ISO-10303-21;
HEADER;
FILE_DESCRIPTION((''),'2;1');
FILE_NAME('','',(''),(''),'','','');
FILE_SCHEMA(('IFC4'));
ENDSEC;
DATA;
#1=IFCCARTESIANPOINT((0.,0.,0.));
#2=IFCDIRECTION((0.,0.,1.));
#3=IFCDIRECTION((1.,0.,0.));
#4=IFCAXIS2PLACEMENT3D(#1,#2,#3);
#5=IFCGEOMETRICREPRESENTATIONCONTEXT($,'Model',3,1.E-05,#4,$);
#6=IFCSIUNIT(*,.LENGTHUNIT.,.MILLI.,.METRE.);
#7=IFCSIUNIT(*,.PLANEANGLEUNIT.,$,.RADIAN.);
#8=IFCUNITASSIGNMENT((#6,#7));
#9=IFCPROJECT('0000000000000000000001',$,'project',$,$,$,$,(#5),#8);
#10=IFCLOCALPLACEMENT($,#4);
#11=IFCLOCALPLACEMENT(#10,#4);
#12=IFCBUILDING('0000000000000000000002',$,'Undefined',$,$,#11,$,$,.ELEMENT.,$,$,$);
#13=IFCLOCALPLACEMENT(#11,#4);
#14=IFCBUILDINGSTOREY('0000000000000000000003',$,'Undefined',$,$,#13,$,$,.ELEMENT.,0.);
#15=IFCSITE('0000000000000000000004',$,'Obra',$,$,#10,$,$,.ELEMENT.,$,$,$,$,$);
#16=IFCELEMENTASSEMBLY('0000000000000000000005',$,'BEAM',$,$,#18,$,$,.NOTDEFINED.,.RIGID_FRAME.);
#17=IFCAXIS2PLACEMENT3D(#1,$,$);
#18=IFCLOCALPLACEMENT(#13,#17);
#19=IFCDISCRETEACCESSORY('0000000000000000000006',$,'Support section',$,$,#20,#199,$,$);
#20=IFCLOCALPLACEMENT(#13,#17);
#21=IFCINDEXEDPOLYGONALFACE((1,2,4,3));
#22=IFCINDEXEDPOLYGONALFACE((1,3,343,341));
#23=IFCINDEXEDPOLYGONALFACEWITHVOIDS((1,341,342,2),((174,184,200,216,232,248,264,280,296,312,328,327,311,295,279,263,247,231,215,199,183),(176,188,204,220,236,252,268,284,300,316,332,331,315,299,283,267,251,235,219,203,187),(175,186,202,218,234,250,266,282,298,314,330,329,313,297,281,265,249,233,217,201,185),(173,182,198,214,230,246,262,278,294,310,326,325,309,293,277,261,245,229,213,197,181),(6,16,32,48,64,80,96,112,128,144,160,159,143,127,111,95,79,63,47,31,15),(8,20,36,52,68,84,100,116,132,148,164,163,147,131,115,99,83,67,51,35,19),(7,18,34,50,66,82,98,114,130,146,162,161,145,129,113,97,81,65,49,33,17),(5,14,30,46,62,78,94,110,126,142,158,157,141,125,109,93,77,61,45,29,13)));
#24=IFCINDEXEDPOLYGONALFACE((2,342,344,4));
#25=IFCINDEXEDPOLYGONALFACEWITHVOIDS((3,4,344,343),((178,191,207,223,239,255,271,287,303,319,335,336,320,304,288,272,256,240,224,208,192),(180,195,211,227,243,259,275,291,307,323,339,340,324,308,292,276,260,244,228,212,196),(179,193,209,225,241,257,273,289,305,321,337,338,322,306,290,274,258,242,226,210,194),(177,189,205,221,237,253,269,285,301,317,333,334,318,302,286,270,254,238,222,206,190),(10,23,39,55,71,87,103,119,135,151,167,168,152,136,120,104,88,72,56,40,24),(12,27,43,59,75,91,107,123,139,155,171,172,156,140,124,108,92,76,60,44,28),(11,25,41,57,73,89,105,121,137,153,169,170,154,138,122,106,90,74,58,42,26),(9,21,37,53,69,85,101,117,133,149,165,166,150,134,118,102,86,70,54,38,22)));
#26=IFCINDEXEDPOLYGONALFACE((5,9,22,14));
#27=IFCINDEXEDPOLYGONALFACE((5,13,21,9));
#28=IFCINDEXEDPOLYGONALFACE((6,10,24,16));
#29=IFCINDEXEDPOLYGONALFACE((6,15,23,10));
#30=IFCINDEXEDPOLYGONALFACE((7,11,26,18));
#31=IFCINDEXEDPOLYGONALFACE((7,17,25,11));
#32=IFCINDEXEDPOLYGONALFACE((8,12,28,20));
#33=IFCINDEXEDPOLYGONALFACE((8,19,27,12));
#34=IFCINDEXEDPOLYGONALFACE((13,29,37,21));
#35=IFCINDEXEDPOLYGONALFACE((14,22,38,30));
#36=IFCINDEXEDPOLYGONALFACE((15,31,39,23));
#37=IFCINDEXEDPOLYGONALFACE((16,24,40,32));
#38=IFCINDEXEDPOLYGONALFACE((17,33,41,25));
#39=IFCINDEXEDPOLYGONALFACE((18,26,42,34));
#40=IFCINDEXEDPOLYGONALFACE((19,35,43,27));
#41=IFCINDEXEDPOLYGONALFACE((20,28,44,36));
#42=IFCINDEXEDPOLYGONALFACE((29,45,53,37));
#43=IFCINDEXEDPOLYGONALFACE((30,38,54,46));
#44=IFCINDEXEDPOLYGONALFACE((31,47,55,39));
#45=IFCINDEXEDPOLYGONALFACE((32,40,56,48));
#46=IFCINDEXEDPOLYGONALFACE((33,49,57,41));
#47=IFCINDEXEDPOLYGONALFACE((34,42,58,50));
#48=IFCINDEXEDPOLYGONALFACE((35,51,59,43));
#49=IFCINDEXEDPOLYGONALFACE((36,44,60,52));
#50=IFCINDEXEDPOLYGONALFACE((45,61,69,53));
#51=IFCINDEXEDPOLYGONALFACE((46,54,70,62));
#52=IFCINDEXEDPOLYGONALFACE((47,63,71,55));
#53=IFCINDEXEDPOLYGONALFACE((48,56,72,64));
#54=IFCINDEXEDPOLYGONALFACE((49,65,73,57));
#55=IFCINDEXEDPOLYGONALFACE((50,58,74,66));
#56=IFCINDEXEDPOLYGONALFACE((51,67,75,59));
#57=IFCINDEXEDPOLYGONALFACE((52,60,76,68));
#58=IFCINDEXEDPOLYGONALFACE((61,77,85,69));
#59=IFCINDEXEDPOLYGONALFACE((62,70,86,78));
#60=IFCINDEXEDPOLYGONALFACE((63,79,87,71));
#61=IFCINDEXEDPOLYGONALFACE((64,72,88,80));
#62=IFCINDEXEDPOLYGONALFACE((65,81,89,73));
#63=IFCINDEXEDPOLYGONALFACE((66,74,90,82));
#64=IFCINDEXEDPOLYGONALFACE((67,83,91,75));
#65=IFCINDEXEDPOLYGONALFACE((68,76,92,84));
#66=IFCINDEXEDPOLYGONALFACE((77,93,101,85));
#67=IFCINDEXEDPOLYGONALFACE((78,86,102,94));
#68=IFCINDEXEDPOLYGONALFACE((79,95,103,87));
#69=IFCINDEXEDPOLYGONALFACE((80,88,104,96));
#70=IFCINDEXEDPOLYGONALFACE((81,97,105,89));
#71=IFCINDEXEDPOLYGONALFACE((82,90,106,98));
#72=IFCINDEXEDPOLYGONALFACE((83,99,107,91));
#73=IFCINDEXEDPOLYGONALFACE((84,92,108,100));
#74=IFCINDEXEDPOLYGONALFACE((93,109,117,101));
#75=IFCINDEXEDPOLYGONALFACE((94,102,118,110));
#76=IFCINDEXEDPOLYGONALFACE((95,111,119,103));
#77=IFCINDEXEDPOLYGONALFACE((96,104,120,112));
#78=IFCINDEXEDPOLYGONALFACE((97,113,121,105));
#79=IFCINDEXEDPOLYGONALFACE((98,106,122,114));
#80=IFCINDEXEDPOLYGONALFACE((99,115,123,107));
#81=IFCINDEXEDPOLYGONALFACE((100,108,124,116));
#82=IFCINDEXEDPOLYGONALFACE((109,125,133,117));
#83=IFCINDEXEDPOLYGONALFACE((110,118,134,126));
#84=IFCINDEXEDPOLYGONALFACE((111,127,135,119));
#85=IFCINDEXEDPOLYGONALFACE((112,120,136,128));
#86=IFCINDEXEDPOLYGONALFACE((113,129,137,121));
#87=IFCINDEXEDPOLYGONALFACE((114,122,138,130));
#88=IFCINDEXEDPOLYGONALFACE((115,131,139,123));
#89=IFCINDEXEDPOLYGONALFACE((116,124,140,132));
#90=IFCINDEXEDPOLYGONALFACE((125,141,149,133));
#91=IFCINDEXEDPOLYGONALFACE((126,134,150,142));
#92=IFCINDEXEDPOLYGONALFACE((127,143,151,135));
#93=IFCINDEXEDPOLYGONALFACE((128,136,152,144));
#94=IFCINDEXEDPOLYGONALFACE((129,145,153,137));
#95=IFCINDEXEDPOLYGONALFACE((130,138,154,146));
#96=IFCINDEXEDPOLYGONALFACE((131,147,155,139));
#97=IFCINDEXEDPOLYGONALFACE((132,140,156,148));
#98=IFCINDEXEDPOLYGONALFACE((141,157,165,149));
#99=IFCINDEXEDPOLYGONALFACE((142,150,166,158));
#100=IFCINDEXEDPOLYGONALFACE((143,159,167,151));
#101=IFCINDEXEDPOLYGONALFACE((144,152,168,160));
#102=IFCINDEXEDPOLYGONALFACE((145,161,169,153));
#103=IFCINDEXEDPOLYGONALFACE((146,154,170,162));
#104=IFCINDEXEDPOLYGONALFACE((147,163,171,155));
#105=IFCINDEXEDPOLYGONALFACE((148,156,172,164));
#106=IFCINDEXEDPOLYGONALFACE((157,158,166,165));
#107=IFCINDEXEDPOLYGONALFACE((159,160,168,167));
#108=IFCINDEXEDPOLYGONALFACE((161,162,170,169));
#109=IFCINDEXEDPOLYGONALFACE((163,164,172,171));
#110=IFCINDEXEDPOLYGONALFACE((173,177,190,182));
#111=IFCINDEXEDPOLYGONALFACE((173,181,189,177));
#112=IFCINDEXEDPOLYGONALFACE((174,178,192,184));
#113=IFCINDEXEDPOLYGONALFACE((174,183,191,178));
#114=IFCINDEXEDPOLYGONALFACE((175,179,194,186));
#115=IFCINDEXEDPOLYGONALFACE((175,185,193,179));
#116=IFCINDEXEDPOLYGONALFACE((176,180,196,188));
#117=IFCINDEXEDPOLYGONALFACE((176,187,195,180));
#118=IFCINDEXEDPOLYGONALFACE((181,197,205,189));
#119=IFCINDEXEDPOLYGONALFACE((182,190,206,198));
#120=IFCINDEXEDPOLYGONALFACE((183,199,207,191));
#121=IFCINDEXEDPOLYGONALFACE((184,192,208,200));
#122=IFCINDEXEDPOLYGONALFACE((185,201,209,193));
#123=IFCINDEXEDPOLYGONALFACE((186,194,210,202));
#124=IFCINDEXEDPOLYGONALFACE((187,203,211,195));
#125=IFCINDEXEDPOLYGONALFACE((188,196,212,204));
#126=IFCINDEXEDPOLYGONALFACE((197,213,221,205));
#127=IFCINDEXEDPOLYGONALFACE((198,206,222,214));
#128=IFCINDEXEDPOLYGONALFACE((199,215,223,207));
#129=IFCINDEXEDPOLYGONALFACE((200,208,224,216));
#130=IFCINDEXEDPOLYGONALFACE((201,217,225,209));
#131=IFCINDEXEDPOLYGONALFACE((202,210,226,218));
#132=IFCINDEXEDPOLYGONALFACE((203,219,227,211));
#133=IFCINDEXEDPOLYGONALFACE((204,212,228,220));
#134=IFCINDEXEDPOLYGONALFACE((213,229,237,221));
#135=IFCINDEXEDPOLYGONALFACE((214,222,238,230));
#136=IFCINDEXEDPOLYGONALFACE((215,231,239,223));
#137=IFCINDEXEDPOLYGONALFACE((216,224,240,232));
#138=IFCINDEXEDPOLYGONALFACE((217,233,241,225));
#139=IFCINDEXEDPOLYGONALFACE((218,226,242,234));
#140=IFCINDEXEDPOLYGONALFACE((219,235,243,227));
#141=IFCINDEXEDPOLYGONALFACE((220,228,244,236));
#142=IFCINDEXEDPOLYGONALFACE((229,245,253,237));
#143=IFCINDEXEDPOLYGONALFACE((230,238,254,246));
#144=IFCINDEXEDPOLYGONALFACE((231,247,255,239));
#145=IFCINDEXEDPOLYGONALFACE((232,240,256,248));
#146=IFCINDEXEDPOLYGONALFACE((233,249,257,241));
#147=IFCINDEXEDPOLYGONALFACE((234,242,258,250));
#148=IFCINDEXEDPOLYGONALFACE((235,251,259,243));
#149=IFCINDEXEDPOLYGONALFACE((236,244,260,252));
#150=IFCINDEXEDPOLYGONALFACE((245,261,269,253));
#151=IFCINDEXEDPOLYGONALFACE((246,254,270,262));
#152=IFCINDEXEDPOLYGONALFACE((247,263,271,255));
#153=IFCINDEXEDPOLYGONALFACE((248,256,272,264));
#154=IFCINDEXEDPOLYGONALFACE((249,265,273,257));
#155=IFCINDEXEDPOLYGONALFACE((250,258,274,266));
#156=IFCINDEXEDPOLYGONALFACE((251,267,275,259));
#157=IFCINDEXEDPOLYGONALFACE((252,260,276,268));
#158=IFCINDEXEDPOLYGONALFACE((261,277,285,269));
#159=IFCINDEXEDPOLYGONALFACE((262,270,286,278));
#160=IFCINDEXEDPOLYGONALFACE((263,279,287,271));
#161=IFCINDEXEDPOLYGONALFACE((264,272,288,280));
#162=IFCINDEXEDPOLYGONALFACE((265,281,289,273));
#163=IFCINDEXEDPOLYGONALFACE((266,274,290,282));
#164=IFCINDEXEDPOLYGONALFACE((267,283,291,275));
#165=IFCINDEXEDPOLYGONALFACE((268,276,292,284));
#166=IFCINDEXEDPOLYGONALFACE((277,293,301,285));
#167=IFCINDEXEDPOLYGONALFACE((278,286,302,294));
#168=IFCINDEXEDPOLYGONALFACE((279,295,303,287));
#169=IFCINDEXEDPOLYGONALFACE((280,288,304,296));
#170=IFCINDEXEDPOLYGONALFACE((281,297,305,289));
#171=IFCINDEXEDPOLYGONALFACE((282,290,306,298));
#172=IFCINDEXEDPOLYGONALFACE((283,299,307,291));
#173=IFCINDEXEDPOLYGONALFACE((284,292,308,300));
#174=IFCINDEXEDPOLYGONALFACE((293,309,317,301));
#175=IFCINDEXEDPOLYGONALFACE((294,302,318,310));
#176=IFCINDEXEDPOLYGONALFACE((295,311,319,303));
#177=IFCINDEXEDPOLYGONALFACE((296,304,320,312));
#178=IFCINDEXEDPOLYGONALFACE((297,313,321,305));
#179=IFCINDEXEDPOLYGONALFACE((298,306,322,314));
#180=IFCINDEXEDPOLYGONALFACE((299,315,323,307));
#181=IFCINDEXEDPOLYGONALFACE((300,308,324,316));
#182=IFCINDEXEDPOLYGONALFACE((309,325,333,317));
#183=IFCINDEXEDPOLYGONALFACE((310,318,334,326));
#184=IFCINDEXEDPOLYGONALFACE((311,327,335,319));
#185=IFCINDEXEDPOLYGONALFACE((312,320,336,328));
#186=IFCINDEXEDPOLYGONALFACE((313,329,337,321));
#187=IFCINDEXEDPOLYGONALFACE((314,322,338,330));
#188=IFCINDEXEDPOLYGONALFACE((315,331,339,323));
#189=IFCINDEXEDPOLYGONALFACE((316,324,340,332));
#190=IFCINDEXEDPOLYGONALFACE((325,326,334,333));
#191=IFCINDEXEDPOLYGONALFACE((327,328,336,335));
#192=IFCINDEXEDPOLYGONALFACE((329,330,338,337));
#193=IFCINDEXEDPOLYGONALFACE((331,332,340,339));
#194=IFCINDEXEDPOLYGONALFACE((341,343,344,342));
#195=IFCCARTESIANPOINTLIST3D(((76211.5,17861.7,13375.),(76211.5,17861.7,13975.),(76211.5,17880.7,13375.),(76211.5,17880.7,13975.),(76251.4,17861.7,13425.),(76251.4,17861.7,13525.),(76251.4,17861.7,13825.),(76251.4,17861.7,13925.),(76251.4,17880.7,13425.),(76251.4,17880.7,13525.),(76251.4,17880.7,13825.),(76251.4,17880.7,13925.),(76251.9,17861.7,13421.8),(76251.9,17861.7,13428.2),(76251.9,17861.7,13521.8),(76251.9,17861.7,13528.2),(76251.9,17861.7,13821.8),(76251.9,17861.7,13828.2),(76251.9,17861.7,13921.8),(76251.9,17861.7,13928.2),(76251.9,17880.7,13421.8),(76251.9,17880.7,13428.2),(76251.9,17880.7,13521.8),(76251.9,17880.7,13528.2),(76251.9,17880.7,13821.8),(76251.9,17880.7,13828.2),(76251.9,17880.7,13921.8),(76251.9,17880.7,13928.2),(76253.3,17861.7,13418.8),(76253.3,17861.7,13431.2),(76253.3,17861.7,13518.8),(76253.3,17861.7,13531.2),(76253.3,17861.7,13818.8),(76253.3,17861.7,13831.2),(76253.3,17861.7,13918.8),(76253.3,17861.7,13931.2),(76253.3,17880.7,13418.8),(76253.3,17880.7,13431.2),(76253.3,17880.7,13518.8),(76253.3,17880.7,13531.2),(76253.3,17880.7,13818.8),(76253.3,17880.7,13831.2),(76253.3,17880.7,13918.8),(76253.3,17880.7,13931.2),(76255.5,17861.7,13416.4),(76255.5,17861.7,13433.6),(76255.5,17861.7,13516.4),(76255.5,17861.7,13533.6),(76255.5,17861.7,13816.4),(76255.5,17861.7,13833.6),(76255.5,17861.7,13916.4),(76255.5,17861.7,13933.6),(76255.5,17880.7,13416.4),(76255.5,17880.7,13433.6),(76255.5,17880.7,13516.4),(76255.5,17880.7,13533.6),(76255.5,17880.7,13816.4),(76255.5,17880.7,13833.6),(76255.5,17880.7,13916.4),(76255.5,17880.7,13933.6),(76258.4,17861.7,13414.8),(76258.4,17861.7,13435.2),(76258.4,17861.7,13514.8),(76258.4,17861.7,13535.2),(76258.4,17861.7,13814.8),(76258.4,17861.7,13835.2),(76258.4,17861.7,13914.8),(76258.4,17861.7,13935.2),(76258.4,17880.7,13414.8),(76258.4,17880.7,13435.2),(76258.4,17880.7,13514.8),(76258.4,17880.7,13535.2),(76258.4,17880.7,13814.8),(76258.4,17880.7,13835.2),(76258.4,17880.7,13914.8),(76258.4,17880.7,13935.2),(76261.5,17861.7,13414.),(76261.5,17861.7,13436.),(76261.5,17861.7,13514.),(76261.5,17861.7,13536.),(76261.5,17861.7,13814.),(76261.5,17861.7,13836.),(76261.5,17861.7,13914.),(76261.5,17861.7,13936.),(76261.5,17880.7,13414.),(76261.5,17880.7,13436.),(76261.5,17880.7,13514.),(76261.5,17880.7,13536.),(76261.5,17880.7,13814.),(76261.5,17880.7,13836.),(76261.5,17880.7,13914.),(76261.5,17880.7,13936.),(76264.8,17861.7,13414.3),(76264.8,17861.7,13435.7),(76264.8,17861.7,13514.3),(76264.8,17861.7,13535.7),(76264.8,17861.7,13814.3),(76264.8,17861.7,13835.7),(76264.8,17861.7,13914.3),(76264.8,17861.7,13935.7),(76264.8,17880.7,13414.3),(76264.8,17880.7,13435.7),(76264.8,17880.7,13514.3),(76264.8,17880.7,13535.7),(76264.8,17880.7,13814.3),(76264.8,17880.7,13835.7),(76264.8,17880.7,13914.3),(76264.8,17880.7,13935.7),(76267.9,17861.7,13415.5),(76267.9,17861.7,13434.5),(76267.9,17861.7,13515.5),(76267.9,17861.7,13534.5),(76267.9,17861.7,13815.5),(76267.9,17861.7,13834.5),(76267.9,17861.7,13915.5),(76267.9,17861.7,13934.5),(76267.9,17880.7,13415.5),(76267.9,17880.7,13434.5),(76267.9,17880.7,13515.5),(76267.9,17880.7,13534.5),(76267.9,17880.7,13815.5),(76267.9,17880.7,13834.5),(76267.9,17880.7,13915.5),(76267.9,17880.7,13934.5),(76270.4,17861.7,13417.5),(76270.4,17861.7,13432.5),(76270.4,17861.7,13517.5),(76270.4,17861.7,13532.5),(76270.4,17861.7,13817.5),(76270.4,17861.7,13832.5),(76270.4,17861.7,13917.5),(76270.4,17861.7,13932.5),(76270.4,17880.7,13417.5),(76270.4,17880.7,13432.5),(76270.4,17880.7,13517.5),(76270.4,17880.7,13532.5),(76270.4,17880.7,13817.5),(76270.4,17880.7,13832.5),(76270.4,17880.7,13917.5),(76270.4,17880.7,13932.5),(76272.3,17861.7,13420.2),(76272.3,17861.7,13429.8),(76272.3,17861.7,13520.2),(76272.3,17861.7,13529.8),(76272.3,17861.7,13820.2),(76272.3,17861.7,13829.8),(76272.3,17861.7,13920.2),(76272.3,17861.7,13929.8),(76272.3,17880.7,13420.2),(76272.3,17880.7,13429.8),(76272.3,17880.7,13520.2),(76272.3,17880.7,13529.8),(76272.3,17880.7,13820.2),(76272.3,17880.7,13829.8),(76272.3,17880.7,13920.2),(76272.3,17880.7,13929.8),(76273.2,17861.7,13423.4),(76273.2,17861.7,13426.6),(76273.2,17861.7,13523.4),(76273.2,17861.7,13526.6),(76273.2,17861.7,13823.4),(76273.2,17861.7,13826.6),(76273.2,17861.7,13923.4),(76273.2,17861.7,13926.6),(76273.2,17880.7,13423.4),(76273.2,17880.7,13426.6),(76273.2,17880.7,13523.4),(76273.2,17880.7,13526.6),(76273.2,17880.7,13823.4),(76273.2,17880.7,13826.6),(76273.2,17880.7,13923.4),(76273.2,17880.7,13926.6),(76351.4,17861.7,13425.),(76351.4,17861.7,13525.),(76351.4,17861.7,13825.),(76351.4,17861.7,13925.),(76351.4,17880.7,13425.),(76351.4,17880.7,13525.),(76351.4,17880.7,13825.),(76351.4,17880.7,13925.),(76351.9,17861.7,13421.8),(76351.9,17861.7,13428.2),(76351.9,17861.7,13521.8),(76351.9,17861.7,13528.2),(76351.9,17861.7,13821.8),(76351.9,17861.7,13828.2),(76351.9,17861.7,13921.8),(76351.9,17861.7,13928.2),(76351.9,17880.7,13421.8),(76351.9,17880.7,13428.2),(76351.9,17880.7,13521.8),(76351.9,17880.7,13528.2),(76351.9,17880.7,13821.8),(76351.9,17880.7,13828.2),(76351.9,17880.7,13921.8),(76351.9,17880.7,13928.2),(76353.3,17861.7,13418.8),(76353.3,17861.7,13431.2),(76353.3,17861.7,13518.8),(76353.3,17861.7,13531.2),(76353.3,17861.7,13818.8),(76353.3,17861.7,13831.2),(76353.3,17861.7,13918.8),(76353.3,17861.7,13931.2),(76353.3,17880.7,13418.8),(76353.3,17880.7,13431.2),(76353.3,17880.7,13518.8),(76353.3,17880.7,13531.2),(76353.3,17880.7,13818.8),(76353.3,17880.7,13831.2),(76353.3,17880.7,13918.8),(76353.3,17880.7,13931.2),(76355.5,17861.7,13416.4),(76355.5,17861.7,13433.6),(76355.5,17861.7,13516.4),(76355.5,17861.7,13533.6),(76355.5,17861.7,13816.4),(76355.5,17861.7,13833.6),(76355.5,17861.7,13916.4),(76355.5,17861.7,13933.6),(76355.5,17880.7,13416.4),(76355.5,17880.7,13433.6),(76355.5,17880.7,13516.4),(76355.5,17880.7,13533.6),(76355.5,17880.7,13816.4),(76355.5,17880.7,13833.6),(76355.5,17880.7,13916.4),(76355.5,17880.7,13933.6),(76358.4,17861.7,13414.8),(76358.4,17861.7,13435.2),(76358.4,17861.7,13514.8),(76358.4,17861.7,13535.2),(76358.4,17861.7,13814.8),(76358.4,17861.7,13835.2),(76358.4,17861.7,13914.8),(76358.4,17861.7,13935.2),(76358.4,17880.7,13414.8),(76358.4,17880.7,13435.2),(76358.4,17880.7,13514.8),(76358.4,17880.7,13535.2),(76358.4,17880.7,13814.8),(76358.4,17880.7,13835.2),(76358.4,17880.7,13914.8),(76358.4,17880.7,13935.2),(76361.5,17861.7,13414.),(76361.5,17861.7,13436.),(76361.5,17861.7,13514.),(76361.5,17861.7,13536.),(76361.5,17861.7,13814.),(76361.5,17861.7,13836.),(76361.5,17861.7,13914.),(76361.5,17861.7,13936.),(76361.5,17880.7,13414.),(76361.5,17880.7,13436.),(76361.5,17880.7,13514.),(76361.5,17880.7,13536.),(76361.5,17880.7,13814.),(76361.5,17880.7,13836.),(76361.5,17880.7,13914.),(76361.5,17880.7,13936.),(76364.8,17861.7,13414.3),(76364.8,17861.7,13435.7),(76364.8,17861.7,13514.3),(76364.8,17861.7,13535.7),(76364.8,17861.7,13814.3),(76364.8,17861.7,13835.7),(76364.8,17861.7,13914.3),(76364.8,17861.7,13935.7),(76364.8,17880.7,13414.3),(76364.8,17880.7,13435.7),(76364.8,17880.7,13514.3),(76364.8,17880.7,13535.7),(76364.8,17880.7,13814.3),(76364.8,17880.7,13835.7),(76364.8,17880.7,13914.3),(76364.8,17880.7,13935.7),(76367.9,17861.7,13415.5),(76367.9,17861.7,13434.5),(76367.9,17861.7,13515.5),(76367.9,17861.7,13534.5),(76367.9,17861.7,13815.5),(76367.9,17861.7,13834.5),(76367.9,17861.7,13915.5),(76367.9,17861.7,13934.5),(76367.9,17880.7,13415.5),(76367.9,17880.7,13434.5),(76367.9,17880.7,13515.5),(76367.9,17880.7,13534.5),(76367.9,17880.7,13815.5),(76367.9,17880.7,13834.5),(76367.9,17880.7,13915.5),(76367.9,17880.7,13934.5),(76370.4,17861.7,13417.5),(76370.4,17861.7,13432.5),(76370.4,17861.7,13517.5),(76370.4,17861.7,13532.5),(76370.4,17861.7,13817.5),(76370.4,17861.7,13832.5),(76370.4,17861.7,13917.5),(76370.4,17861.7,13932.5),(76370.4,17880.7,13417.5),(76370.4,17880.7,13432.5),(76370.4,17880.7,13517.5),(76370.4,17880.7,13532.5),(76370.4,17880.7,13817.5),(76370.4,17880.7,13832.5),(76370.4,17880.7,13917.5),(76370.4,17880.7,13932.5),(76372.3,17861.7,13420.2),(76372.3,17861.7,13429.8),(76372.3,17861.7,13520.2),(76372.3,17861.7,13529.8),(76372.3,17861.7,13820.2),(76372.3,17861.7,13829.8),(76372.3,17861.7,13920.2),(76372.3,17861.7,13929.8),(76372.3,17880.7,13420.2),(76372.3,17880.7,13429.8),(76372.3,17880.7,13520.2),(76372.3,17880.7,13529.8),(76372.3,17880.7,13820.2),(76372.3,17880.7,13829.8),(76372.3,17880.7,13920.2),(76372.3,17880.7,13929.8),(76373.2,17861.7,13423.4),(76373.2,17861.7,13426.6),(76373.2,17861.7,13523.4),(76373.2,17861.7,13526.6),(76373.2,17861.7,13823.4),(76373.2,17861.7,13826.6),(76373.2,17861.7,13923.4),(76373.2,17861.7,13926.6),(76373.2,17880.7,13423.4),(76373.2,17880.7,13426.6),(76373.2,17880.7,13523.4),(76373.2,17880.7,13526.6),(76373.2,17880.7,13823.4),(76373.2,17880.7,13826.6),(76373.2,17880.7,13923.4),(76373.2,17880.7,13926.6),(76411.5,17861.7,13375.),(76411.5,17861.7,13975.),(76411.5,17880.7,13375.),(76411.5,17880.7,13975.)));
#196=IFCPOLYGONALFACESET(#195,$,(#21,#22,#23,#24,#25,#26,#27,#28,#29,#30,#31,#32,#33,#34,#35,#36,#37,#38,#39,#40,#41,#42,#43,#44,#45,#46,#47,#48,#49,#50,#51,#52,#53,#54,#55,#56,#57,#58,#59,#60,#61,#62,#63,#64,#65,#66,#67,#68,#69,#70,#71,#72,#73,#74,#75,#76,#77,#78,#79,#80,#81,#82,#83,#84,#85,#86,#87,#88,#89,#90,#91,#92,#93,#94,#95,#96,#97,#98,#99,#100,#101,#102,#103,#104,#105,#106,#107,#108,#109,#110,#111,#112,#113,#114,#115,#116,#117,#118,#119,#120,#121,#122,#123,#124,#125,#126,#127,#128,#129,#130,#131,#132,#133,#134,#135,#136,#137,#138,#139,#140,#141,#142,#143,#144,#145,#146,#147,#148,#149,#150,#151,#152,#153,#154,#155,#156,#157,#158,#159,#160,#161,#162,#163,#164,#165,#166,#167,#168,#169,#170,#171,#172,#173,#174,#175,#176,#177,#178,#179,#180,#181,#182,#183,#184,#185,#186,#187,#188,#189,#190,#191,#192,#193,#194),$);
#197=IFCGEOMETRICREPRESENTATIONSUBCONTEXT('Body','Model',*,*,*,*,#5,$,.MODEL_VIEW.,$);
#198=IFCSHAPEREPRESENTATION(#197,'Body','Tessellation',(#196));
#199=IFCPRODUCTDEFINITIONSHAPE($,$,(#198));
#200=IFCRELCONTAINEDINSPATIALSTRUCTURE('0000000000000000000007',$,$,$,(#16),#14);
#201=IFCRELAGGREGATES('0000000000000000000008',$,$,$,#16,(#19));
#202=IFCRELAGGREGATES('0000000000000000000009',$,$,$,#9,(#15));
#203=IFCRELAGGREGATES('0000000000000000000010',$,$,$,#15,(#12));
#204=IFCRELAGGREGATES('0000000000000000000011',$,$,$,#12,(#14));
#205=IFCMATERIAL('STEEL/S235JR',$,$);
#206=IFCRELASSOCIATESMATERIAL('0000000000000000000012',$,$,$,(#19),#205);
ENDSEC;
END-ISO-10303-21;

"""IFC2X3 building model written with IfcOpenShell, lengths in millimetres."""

from ifc_helpers import new_model, si_unit, frame, origin_with_axes, origin_2d_with_axis, place, context, subcontext, project, spatial, rectangle, circle, extrude, source, transform, mapped, material, element, aggregate, save


model = new_model("IFC2X3")

# Units and contexts
model_context = context("Model", 3, precision=1e-05, world=origin_with_axes())
body_context = subcontext(model_context, "Body", "Model", "MODEL_VIEW")
ifc_project = project(units=[si_unit("LENGTHUNIT", "METRE", prefix="MILLI"), si_unit("PLANEANGLEUNIT", "RADIAN")], contexts=[model_context])

# Site, building, storey
site_placement = place(None, origin_with_axes())
site = spatial("IfcSite", under=ifc_project, at=site_placement, Name="Obra", CompositionType="ELEMENT")
building_placement = place(site_placement, origin_with_axes())
building = spatial("IfcBuilding", under=site, at=building_placement, Name="Undefined", CompositionType="ELEMENT")
storey_placement = place(building_placement, origin_with_axes())
storey = spatial("IfcBuildingStorey", under=building, at=storey_placement, Name="Undefined", CompositionType="ELEMENT", Elevation=0.0)

# Shared definitions
ifc_material_1 = material(Name="STEEL/S235JR")

# Element assembly
assembly_1_placement = place(storey_placement, origin_with_axes())
assembly_1 = element("IfcElementAssembly", 1, at=assembly_1_placement, inside=storey, Name="BEAM", AssemblyPlace="NOTDEFINED", PredefinedType="RIGID_FRAME")

# Discrete accessory, opening
discrete_accessory_1_placement = place(assembly_1_placement, frame((76211.5, 17871.2, 13675.0), z_axis=(0.0, 0.0, -1.0), x_axis=(1.0, 0.0, 0.0)))
discrete_accessory_1 = element("IfcDiscreteAccessory", 2, at=discrete_accessory_1_placement, material=ifc_material_1, Name="Support section", context=body_context, shape_type="SweptSolid", body=[
    extrude(rectangle(XDim=19.0, YDim=600.0, at=origin_2d_with_axis()), frame((200.0, 0.0, 0.0), z_axis=(-1.0, 0.0, 0.0), x_axis=(0.0, -1.0, 0.0)), (0.0, 0.0, 1.0), 200.0),
])
shared_shape_1 = source(origin_with_axes(), body_context, "Body", "SweptSolid", [
    extrude(circle(Radius=11.0, at=origin_2d_with_axis()), frame((0.0, -19.1, 0.0), z_axis=(0.0, 1.0, 0.0), x_axis=(1.0, 0.0, 0.0)), (0.0, 0.0, 1.0), 19.2),
])
opening_1_placement = place(assembly_1_placement, frame((76407.5, 17880.7, 13675.0), z_axis=(0.0, 0.0, -1.0), x_axis=(-1.0, 0.0, 0.0)))
element("IfcOpeningElement", 3, at=opening_1_placement, cuts=discrete_accessory_1, ObjectType="Opening", context=body_context, shape_type="MappedRepresentation", body=[
    mapped(shared_shape_1, transform((45.1, 0.0, -250.0))),
    mapped(shared_shape_1, transform((45.1, 0.0, -150.0))),
    mapped(shared_shape_1, transform((45.1, 0.0, 150.0))),
    mapped(shared_shape_1, transform((45.1, 0.0, 250.0))),
    mapped(shared_shape_1, transform((145.1, 0.0, -250.0))),
    mapped(shared_shape_1, transform((145.1, 0.0, -150.0))),
    mapped(shared_shape_1, transform((145.1, 0.0, 150.0))),
    mapped(shared_shape_1, transform((145.1, 0.0, 250.0))),
])
aggregate(assembly_1, [discrete_accessory_1])

save(model, "model.ifc")
